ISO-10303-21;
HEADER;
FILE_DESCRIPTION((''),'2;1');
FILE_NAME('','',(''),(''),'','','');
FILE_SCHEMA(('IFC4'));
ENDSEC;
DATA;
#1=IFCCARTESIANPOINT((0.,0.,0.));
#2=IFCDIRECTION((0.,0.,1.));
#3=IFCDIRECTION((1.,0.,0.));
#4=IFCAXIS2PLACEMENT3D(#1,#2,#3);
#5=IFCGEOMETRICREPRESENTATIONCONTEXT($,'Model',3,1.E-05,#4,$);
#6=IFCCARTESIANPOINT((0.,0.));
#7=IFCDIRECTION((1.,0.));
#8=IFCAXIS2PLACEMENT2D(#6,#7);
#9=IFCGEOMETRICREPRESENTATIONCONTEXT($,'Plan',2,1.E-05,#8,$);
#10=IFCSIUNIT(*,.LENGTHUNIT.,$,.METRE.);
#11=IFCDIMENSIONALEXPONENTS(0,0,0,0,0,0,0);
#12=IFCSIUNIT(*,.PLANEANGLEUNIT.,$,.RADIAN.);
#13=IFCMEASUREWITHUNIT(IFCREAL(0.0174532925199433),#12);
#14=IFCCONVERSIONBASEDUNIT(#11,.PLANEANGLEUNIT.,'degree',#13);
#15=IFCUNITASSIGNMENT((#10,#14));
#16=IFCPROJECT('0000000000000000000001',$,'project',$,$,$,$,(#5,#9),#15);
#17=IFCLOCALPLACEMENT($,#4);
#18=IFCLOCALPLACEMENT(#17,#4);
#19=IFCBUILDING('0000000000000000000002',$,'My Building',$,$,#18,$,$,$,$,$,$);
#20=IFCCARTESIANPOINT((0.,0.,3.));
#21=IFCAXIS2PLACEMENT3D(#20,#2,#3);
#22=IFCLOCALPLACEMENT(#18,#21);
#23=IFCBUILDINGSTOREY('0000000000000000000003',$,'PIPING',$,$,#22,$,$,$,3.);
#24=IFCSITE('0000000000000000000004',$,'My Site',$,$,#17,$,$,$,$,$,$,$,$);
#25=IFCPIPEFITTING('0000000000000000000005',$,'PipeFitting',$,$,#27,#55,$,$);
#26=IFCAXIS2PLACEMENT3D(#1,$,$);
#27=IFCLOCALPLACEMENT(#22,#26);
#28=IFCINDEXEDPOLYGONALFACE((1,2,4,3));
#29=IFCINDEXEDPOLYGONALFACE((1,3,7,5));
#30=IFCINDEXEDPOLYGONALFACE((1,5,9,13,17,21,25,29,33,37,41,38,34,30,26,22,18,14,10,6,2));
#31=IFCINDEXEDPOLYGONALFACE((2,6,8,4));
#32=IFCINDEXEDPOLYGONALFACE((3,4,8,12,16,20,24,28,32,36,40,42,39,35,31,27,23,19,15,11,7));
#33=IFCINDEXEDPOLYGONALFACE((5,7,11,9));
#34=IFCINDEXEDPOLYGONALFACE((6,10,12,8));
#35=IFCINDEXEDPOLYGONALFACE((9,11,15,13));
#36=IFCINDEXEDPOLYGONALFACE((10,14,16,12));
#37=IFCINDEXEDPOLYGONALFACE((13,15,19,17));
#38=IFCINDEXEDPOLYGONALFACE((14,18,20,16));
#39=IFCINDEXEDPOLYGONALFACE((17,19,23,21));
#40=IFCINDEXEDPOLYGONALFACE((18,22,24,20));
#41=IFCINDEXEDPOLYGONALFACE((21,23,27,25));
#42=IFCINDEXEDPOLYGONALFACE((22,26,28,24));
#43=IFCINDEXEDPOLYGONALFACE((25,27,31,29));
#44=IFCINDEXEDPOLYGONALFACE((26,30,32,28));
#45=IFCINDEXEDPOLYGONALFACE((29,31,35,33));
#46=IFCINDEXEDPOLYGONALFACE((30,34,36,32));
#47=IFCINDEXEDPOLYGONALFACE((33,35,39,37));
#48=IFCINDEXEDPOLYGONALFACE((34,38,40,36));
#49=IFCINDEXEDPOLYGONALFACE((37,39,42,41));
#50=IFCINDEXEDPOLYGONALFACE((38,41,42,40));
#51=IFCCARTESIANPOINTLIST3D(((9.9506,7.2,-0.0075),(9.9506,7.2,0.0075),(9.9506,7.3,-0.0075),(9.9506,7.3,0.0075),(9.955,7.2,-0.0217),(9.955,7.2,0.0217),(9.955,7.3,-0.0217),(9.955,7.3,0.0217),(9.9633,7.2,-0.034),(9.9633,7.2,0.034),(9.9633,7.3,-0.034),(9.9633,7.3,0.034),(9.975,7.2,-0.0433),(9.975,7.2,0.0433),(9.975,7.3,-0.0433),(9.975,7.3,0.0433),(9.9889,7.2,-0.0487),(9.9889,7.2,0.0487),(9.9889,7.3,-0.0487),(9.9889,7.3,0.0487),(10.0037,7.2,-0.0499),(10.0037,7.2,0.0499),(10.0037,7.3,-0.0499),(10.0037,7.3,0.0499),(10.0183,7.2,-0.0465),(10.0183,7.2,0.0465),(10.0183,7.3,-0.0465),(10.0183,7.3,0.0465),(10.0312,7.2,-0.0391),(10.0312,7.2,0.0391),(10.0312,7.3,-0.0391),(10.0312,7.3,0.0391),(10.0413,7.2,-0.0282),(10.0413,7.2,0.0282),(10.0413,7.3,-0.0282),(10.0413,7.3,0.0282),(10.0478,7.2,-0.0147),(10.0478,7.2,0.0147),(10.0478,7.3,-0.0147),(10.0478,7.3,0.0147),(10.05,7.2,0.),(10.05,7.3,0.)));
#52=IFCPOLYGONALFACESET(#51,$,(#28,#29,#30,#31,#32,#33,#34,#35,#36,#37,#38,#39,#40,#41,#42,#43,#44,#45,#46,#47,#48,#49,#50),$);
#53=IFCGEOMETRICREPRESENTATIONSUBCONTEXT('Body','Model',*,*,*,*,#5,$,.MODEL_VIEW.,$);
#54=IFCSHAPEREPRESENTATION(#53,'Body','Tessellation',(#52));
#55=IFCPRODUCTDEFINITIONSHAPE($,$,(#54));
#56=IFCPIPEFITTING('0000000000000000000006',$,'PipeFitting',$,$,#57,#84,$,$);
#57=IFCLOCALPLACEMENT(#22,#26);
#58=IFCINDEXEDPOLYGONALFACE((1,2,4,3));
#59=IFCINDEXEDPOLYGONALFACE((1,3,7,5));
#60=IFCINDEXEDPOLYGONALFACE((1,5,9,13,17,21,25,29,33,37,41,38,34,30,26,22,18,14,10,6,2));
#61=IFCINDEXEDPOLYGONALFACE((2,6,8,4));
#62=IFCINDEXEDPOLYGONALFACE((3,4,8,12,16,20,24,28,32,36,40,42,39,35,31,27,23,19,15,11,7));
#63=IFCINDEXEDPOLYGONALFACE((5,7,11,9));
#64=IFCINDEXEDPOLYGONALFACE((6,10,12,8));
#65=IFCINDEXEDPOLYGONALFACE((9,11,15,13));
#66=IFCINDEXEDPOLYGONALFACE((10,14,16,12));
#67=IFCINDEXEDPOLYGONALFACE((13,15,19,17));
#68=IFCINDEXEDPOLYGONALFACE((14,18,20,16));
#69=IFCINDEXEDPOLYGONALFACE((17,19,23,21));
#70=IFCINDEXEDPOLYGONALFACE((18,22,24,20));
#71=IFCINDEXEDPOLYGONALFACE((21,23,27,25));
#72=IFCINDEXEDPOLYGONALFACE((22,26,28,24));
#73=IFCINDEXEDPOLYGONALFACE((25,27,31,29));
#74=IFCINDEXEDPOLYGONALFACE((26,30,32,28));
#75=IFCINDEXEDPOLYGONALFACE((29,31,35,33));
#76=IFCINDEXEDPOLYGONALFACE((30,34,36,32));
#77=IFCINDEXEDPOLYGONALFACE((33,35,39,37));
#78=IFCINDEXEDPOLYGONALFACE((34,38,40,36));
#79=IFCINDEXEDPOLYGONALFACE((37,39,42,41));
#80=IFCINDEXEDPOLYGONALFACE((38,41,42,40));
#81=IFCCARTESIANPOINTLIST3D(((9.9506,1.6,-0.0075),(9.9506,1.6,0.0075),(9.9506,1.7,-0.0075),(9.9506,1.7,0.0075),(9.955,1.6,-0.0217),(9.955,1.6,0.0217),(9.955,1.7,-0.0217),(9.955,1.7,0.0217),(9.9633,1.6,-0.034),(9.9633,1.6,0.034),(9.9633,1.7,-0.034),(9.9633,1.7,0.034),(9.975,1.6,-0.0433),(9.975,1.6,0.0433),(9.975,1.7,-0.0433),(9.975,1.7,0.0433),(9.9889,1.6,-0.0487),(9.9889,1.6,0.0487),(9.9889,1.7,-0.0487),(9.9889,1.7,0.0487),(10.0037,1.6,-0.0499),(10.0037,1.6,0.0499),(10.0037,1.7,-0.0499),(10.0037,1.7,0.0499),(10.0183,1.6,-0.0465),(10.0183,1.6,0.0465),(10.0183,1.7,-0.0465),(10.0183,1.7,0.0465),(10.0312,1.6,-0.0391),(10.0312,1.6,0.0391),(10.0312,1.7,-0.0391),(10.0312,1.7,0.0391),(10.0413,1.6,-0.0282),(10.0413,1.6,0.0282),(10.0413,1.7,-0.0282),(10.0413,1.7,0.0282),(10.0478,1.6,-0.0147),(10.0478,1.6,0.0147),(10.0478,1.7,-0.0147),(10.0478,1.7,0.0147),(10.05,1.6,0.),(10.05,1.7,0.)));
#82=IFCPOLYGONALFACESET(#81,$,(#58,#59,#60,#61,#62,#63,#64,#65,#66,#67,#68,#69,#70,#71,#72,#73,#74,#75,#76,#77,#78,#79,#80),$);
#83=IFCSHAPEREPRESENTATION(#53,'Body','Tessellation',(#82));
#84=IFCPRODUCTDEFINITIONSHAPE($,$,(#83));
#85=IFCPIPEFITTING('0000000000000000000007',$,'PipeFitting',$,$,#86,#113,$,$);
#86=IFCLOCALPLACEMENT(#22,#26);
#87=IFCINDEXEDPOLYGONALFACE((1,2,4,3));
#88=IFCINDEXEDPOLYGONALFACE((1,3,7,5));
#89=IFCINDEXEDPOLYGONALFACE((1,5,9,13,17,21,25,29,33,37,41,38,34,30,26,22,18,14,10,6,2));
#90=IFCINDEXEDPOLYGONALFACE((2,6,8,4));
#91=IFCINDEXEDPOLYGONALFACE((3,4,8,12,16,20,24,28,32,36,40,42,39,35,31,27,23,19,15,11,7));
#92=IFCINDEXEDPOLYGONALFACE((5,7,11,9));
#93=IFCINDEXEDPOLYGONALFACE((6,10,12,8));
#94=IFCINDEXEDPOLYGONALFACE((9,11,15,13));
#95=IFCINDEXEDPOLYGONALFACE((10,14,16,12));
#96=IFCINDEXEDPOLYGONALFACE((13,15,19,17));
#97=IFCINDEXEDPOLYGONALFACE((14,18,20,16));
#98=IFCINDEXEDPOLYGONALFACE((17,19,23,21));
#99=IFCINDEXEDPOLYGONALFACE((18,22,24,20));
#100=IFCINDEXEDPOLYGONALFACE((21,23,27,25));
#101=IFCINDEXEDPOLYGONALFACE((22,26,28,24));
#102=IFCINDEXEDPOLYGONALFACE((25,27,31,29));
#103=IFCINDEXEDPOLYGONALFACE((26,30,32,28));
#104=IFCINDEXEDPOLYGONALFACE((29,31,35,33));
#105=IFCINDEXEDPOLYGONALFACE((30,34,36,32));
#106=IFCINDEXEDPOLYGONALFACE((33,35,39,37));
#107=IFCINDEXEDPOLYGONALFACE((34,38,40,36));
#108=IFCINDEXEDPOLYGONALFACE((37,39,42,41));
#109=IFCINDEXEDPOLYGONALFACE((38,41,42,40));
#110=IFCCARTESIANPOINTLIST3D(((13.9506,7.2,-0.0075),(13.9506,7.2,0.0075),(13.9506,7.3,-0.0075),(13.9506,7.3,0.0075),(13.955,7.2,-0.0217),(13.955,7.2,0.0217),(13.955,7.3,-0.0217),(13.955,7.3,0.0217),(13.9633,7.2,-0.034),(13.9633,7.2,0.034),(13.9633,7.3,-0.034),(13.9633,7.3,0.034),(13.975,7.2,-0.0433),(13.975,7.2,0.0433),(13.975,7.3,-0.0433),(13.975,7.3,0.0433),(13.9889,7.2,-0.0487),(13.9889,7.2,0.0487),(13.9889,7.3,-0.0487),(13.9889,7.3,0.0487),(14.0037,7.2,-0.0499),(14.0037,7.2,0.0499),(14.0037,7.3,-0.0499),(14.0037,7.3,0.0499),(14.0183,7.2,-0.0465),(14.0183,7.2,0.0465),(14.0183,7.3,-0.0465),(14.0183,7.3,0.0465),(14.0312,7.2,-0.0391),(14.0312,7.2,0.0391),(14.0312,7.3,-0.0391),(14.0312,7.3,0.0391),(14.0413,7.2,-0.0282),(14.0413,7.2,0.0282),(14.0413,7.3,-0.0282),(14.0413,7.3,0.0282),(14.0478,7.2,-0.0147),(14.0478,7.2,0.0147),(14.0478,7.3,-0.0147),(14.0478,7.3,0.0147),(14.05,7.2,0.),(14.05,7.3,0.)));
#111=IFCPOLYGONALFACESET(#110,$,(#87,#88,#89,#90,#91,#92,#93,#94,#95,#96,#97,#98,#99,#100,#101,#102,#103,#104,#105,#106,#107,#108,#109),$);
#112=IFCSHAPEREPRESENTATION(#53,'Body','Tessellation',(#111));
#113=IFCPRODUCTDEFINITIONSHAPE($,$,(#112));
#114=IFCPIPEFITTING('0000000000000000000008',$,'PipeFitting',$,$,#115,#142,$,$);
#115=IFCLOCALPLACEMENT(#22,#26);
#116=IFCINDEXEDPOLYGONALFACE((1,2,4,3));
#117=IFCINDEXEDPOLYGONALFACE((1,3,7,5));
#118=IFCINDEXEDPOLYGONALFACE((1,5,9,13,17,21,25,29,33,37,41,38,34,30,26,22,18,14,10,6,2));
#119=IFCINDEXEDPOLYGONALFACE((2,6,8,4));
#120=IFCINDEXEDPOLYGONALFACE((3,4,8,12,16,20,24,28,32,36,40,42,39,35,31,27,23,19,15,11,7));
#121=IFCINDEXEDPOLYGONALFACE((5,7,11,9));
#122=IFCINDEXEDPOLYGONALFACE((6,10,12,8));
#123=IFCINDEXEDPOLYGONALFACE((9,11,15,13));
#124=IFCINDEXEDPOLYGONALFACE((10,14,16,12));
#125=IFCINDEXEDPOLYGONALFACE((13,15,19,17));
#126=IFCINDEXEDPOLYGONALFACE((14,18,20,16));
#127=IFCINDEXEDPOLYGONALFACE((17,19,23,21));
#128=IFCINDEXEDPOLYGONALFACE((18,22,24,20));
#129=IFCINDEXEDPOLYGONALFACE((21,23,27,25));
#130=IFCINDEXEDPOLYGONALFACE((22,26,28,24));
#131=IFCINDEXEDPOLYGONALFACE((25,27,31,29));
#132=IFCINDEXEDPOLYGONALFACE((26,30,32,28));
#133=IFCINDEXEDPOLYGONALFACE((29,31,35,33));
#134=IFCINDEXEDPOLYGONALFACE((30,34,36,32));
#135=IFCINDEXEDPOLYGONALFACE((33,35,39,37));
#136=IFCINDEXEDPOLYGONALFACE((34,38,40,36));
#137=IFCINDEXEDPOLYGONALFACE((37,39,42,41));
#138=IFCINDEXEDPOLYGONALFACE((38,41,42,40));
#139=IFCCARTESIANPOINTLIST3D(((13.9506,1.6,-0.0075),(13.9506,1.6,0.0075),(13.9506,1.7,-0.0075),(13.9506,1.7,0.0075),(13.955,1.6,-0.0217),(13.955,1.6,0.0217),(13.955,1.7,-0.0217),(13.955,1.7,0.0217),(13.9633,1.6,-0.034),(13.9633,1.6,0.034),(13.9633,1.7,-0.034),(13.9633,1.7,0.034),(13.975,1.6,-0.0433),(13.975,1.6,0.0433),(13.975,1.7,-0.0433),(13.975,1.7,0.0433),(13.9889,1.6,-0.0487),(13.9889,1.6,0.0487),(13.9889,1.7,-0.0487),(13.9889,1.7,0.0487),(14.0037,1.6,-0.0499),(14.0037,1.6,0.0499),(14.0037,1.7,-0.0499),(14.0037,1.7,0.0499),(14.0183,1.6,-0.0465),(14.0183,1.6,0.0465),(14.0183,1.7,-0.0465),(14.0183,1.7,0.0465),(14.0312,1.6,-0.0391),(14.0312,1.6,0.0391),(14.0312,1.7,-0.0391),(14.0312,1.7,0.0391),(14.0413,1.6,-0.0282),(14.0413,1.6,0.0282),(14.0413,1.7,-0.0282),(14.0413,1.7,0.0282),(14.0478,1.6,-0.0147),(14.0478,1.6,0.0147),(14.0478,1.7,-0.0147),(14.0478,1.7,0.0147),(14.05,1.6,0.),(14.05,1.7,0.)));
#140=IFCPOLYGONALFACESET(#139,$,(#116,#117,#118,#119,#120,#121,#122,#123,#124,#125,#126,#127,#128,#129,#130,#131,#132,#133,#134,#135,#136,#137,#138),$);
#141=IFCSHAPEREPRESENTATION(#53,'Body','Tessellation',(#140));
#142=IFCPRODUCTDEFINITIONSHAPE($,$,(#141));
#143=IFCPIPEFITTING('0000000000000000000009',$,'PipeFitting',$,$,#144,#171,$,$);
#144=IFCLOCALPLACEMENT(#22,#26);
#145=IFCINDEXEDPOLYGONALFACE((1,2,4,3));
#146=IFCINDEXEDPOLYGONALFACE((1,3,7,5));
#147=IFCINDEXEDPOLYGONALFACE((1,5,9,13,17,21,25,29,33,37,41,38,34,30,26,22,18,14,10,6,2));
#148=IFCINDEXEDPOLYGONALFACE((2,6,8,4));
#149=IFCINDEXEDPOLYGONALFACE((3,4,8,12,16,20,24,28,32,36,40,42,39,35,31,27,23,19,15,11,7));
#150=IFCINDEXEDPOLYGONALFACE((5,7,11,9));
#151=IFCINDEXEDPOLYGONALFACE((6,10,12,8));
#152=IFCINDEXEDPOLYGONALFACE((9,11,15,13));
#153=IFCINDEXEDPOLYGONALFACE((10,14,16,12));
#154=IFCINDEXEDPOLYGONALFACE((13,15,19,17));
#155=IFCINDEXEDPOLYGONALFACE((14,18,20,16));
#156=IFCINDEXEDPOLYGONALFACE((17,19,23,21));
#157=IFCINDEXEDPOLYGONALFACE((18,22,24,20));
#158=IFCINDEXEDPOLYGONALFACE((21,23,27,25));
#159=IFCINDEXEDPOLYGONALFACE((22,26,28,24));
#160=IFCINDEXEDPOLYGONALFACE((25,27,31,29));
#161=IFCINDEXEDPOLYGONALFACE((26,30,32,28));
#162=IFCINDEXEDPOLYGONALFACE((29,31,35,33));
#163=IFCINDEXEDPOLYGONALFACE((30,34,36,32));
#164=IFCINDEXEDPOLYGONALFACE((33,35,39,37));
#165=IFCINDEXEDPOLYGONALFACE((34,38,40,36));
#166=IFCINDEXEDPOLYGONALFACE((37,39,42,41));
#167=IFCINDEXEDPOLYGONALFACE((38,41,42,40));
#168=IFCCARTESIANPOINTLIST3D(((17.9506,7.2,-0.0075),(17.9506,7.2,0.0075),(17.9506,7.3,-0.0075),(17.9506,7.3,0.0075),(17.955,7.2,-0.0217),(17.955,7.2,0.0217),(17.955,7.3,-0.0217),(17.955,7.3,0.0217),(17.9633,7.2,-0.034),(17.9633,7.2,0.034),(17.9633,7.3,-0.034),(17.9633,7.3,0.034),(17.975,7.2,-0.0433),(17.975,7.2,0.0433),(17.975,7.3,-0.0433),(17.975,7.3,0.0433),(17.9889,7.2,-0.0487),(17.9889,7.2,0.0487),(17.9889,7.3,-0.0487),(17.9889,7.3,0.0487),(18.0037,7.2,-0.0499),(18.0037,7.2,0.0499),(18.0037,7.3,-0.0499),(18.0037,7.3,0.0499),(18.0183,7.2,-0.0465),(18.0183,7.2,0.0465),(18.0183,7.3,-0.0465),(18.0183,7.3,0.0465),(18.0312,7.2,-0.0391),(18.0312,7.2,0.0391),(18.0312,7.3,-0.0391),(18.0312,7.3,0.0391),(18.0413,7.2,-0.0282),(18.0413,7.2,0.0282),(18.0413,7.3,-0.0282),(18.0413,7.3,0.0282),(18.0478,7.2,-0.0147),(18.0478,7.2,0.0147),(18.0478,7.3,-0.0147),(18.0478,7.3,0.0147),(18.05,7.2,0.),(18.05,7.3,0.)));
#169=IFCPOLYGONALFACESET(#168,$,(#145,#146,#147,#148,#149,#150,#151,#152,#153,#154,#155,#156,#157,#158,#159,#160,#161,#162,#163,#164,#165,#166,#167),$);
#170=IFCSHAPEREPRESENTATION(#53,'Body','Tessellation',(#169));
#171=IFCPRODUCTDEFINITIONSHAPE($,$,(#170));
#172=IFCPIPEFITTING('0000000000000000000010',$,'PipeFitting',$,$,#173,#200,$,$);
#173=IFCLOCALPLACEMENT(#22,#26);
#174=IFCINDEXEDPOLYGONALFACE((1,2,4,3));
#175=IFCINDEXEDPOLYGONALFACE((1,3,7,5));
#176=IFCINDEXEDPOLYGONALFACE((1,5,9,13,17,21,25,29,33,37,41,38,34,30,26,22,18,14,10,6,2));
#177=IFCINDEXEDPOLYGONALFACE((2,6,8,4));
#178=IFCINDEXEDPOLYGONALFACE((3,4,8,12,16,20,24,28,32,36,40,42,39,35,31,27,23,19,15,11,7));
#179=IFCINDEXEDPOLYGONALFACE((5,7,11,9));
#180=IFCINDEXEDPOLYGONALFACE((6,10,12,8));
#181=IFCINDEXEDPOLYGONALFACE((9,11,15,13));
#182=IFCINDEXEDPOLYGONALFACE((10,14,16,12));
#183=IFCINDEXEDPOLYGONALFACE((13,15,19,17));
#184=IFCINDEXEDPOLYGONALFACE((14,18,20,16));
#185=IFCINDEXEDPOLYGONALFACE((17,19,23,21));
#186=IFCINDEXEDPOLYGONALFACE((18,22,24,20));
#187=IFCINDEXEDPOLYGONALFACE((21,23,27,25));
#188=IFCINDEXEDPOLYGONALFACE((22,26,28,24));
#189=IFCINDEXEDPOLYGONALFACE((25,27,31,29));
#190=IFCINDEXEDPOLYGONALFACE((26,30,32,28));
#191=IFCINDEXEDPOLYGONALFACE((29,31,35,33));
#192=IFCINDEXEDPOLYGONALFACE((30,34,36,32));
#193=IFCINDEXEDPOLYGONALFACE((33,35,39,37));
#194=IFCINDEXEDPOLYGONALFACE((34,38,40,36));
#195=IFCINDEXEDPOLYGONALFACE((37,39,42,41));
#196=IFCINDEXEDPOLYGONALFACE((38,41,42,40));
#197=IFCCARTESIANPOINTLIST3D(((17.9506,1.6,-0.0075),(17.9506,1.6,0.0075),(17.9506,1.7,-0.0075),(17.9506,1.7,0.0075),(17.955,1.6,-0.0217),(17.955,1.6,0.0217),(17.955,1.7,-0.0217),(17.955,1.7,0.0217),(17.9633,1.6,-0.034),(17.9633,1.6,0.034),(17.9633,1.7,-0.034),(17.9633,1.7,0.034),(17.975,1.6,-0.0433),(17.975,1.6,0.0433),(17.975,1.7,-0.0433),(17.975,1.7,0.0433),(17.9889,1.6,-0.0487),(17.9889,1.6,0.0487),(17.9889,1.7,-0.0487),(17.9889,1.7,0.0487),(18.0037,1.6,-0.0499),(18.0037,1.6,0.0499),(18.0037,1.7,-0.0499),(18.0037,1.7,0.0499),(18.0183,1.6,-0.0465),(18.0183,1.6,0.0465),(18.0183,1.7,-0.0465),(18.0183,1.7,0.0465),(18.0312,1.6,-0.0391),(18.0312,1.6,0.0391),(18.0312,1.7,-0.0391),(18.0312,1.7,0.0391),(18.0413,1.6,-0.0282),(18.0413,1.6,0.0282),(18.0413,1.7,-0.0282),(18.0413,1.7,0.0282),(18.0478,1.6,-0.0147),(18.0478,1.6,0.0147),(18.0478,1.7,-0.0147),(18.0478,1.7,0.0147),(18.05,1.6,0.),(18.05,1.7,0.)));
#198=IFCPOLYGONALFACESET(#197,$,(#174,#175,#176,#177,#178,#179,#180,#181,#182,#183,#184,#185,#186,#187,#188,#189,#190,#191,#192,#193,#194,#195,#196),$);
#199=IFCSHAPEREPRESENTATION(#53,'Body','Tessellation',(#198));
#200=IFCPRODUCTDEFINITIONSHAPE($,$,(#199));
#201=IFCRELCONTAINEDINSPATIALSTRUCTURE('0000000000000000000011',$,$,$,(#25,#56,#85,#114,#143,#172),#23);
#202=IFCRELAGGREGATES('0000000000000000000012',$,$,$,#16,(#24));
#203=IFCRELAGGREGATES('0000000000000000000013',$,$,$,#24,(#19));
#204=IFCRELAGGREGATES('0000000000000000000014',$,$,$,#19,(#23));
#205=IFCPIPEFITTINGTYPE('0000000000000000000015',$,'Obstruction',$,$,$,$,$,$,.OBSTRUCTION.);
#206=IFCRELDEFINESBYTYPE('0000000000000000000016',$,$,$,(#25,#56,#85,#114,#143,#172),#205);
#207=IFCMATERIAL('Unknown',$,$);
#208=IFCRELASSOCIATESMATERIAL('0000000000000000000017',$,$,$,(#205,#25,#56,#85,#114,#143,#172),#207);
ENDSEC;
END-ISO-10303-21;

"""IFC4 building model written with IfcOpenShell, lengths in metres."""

from ifc_helpers import new_model, entity, si_unit, converted_unit, frame, origin_with_axes, origin_2d_with_axis, place, context, subcontext, project, spatial, circle, extrude, material, material_profile, profile_set, profile_usage, type_object, element, save


model = new_model("IFC4")

# Units and contexts
model_context = context("Model", 3, precision=1e-05, world=origin_with_axes())
plan_context = context("Plan", 2, precision=1e-05, world=origin_2d_with_axis())
body_context = subcontext(model_context, "Body", "Model", "MODEL_VIEW")
ifc_project = project(units=[si_unit("LENGTHUNIT", "METRE"), converted_unit("PLANEANGLEUNIT", "degree", entity("IfcReal", 0.0174532925199433), si_unit("PLANEANGLEUNIT", "RADIAN"), dimensions=[0, 0, 0, 0, 0, 0, 0])], contexts=[model_context, plan_context])

# Site, building, storey
site_placement = place(None, origin_with_axes())
site = spatial("IfcSite", under=ifc_project, at=site_placement, Name="My Site")
building_placement = place(site_placement, origin_with_axes())
building = spatial("IfcBuilding", under=site, at=building_placement, Name="My Building")
storey_placement = place(building_placement, frame((0.0, 0.0, 3.0), z_axis=(0.0, 0.0, 1.0), x_axis=(1.0, 0.0, 0.0)))
storey = spatial("IfcBuildingStorey", under=building, at=storey_placement, Name="PIPING", Elevation=3.0)

# Shared definitions
ifc_material = material(Name="Unknown")

# Pipe fittings
ifc_material_profile_1 = material_profile(ifc_material, circle(Radius=0.05))
ifc_profile_set_1 = profile_set([ifc_material_profile_1])
pipe_fitting_type = type_object("IfcPipeFittingType", Name="Obstruction", PredefinedType="OBSTRUCTION", material=ifc_profile_set_1)
ifc_profile_usage_1 = profile_usage(ifc_profile_set_1, cardinal=5)
pipe_fitting_1_placement = place(storey_placement, frame((10.0, 7.3, 0.0), z_axis=(0.0, -1.0, 0.0), x_axis=(1.0, 0.0, 0.0)))
element("IfcPipeFitting", 1, at=pipe_fitting_1_placement, inside=storey, type_object=pipe_fitting_type, material=ifc_profile_usage_1, Name="PipeFitting", context=body_context, shape_type="SweptSolid", body=[
    extrude(circle(Radius=0.05), origin_with_axes(), (0.0, 0.0, 1.0), 0.1),
])
ifc_profile_usage_2 = profile_usage(ifc_profile_set_1, cardinal=5)
pipe_fitting_2_placement = place(storey_placement, frame((10.0, 1.7, 0.0), z_axis=(0.0, -1.0, 0.0), x_axis=(1.0, 0.0, 0.0)))
element("IfcPipeFitting", 2, at=pipe_fitting_2_placement, inside=storey, type_object=pipe_fitting_type, material=ifc_profile_usage_2, Name="PipeFitting", context=body_context, shape_type="SweptSolid", body=[
    extrude(circle(Radius=0.05), origin_with_axes(), (0.0, 0.0, 1.0), 0.1),
])
ifc_profile_usage_3 = profile_usage(ifc_profile_set_1, cardinal=5)
pipe_fitting_3_placement = place(storey_placement, frame((14.0, 7.3, 0.0), z_axis=(0.0, -1.0, 0.0), x_axis=(1.0, 0.0, 0.0)))
element("IfcPipeFitting", 3, at=pipe_fitting_3_placement, inside=storey, type_object=pipe_fitting_type, material=ifc_profile_usage_3, Name="PipeFitting", context=body_context, shape_type="SweptSolid", body=[
    extrude(circle(Radius=0.05), origin_with_axes(), (0.0, 0.0, 1.0), 0.1),
])
ifc_profile_usage_4 = profile_usage(ifc_profile_set_1, cardinal=5)
pipe_fitting_4_placement = place(storey_placement, frame((14.0, 1.7, 0.0), z_axis=(0.0, -1.0, 0.0), x_axis=(1.0, 0.0, 0.0)))
element("IfcPipeFitting", 4, at=pipe_fitting_4_placement, inside=storey, type_object=pipe_fitting_type, material=ifc_profile_usage_4, Name="PipeFitting", context=body_context, shape_type="SweptSolid", body=[
    extrude(circle(Radius=0.05), origin_with_axes(), (0.0, 0.0, 1.0), 0.1),
])
ifc_profile_usage_5 = profile_usage(ifc_profile_set_1, cardinal=5)
pipe_fitting_5_placement = place(storey_placement, frame((18.0, 7.3, 0.0), z_axis=(0.0, -1.0, 0.0), x_axis=(1.0, 0.0, 0.0)))
element("IfcPipeFitting", 5, at=pipe_fitting_5_placement, inside=storey, type_object=pipe_fitting_type, material=ifc_profile_usage_5, Name="PipeFitting", context=body_context, shape_type="SweptSolid", body=[
    extrude(circle(Radius=0.05), origin_with_axes(), (0.0, 0.0, 1.0), 0.1),
])
ifc_profile_usage_6 = profile_usage(ifc_profile_set_1, cardinal=5)
pipe_fitting_6_placement = place(storey_placement, frame((18.0, 1.7, 0.0), z_axis=(0.0, -1.0, 0.0), x_axis=(1.0, 0.0, 0.0)))
element("IfcPipeFitting", 6, at=pipe_fitting_6_placement, inside=storey, type_object=pipe_fitting_type, material=ifc_profile_usage_6, Name="PipeFitting", context=body_context, shape_type="SweptSolid", body=[
    extrude(circle(Radius=0.05), origin_with_axes(), (0.0, 0.0, 1.0), 0.1),
])

save(model, "model.ifc")
